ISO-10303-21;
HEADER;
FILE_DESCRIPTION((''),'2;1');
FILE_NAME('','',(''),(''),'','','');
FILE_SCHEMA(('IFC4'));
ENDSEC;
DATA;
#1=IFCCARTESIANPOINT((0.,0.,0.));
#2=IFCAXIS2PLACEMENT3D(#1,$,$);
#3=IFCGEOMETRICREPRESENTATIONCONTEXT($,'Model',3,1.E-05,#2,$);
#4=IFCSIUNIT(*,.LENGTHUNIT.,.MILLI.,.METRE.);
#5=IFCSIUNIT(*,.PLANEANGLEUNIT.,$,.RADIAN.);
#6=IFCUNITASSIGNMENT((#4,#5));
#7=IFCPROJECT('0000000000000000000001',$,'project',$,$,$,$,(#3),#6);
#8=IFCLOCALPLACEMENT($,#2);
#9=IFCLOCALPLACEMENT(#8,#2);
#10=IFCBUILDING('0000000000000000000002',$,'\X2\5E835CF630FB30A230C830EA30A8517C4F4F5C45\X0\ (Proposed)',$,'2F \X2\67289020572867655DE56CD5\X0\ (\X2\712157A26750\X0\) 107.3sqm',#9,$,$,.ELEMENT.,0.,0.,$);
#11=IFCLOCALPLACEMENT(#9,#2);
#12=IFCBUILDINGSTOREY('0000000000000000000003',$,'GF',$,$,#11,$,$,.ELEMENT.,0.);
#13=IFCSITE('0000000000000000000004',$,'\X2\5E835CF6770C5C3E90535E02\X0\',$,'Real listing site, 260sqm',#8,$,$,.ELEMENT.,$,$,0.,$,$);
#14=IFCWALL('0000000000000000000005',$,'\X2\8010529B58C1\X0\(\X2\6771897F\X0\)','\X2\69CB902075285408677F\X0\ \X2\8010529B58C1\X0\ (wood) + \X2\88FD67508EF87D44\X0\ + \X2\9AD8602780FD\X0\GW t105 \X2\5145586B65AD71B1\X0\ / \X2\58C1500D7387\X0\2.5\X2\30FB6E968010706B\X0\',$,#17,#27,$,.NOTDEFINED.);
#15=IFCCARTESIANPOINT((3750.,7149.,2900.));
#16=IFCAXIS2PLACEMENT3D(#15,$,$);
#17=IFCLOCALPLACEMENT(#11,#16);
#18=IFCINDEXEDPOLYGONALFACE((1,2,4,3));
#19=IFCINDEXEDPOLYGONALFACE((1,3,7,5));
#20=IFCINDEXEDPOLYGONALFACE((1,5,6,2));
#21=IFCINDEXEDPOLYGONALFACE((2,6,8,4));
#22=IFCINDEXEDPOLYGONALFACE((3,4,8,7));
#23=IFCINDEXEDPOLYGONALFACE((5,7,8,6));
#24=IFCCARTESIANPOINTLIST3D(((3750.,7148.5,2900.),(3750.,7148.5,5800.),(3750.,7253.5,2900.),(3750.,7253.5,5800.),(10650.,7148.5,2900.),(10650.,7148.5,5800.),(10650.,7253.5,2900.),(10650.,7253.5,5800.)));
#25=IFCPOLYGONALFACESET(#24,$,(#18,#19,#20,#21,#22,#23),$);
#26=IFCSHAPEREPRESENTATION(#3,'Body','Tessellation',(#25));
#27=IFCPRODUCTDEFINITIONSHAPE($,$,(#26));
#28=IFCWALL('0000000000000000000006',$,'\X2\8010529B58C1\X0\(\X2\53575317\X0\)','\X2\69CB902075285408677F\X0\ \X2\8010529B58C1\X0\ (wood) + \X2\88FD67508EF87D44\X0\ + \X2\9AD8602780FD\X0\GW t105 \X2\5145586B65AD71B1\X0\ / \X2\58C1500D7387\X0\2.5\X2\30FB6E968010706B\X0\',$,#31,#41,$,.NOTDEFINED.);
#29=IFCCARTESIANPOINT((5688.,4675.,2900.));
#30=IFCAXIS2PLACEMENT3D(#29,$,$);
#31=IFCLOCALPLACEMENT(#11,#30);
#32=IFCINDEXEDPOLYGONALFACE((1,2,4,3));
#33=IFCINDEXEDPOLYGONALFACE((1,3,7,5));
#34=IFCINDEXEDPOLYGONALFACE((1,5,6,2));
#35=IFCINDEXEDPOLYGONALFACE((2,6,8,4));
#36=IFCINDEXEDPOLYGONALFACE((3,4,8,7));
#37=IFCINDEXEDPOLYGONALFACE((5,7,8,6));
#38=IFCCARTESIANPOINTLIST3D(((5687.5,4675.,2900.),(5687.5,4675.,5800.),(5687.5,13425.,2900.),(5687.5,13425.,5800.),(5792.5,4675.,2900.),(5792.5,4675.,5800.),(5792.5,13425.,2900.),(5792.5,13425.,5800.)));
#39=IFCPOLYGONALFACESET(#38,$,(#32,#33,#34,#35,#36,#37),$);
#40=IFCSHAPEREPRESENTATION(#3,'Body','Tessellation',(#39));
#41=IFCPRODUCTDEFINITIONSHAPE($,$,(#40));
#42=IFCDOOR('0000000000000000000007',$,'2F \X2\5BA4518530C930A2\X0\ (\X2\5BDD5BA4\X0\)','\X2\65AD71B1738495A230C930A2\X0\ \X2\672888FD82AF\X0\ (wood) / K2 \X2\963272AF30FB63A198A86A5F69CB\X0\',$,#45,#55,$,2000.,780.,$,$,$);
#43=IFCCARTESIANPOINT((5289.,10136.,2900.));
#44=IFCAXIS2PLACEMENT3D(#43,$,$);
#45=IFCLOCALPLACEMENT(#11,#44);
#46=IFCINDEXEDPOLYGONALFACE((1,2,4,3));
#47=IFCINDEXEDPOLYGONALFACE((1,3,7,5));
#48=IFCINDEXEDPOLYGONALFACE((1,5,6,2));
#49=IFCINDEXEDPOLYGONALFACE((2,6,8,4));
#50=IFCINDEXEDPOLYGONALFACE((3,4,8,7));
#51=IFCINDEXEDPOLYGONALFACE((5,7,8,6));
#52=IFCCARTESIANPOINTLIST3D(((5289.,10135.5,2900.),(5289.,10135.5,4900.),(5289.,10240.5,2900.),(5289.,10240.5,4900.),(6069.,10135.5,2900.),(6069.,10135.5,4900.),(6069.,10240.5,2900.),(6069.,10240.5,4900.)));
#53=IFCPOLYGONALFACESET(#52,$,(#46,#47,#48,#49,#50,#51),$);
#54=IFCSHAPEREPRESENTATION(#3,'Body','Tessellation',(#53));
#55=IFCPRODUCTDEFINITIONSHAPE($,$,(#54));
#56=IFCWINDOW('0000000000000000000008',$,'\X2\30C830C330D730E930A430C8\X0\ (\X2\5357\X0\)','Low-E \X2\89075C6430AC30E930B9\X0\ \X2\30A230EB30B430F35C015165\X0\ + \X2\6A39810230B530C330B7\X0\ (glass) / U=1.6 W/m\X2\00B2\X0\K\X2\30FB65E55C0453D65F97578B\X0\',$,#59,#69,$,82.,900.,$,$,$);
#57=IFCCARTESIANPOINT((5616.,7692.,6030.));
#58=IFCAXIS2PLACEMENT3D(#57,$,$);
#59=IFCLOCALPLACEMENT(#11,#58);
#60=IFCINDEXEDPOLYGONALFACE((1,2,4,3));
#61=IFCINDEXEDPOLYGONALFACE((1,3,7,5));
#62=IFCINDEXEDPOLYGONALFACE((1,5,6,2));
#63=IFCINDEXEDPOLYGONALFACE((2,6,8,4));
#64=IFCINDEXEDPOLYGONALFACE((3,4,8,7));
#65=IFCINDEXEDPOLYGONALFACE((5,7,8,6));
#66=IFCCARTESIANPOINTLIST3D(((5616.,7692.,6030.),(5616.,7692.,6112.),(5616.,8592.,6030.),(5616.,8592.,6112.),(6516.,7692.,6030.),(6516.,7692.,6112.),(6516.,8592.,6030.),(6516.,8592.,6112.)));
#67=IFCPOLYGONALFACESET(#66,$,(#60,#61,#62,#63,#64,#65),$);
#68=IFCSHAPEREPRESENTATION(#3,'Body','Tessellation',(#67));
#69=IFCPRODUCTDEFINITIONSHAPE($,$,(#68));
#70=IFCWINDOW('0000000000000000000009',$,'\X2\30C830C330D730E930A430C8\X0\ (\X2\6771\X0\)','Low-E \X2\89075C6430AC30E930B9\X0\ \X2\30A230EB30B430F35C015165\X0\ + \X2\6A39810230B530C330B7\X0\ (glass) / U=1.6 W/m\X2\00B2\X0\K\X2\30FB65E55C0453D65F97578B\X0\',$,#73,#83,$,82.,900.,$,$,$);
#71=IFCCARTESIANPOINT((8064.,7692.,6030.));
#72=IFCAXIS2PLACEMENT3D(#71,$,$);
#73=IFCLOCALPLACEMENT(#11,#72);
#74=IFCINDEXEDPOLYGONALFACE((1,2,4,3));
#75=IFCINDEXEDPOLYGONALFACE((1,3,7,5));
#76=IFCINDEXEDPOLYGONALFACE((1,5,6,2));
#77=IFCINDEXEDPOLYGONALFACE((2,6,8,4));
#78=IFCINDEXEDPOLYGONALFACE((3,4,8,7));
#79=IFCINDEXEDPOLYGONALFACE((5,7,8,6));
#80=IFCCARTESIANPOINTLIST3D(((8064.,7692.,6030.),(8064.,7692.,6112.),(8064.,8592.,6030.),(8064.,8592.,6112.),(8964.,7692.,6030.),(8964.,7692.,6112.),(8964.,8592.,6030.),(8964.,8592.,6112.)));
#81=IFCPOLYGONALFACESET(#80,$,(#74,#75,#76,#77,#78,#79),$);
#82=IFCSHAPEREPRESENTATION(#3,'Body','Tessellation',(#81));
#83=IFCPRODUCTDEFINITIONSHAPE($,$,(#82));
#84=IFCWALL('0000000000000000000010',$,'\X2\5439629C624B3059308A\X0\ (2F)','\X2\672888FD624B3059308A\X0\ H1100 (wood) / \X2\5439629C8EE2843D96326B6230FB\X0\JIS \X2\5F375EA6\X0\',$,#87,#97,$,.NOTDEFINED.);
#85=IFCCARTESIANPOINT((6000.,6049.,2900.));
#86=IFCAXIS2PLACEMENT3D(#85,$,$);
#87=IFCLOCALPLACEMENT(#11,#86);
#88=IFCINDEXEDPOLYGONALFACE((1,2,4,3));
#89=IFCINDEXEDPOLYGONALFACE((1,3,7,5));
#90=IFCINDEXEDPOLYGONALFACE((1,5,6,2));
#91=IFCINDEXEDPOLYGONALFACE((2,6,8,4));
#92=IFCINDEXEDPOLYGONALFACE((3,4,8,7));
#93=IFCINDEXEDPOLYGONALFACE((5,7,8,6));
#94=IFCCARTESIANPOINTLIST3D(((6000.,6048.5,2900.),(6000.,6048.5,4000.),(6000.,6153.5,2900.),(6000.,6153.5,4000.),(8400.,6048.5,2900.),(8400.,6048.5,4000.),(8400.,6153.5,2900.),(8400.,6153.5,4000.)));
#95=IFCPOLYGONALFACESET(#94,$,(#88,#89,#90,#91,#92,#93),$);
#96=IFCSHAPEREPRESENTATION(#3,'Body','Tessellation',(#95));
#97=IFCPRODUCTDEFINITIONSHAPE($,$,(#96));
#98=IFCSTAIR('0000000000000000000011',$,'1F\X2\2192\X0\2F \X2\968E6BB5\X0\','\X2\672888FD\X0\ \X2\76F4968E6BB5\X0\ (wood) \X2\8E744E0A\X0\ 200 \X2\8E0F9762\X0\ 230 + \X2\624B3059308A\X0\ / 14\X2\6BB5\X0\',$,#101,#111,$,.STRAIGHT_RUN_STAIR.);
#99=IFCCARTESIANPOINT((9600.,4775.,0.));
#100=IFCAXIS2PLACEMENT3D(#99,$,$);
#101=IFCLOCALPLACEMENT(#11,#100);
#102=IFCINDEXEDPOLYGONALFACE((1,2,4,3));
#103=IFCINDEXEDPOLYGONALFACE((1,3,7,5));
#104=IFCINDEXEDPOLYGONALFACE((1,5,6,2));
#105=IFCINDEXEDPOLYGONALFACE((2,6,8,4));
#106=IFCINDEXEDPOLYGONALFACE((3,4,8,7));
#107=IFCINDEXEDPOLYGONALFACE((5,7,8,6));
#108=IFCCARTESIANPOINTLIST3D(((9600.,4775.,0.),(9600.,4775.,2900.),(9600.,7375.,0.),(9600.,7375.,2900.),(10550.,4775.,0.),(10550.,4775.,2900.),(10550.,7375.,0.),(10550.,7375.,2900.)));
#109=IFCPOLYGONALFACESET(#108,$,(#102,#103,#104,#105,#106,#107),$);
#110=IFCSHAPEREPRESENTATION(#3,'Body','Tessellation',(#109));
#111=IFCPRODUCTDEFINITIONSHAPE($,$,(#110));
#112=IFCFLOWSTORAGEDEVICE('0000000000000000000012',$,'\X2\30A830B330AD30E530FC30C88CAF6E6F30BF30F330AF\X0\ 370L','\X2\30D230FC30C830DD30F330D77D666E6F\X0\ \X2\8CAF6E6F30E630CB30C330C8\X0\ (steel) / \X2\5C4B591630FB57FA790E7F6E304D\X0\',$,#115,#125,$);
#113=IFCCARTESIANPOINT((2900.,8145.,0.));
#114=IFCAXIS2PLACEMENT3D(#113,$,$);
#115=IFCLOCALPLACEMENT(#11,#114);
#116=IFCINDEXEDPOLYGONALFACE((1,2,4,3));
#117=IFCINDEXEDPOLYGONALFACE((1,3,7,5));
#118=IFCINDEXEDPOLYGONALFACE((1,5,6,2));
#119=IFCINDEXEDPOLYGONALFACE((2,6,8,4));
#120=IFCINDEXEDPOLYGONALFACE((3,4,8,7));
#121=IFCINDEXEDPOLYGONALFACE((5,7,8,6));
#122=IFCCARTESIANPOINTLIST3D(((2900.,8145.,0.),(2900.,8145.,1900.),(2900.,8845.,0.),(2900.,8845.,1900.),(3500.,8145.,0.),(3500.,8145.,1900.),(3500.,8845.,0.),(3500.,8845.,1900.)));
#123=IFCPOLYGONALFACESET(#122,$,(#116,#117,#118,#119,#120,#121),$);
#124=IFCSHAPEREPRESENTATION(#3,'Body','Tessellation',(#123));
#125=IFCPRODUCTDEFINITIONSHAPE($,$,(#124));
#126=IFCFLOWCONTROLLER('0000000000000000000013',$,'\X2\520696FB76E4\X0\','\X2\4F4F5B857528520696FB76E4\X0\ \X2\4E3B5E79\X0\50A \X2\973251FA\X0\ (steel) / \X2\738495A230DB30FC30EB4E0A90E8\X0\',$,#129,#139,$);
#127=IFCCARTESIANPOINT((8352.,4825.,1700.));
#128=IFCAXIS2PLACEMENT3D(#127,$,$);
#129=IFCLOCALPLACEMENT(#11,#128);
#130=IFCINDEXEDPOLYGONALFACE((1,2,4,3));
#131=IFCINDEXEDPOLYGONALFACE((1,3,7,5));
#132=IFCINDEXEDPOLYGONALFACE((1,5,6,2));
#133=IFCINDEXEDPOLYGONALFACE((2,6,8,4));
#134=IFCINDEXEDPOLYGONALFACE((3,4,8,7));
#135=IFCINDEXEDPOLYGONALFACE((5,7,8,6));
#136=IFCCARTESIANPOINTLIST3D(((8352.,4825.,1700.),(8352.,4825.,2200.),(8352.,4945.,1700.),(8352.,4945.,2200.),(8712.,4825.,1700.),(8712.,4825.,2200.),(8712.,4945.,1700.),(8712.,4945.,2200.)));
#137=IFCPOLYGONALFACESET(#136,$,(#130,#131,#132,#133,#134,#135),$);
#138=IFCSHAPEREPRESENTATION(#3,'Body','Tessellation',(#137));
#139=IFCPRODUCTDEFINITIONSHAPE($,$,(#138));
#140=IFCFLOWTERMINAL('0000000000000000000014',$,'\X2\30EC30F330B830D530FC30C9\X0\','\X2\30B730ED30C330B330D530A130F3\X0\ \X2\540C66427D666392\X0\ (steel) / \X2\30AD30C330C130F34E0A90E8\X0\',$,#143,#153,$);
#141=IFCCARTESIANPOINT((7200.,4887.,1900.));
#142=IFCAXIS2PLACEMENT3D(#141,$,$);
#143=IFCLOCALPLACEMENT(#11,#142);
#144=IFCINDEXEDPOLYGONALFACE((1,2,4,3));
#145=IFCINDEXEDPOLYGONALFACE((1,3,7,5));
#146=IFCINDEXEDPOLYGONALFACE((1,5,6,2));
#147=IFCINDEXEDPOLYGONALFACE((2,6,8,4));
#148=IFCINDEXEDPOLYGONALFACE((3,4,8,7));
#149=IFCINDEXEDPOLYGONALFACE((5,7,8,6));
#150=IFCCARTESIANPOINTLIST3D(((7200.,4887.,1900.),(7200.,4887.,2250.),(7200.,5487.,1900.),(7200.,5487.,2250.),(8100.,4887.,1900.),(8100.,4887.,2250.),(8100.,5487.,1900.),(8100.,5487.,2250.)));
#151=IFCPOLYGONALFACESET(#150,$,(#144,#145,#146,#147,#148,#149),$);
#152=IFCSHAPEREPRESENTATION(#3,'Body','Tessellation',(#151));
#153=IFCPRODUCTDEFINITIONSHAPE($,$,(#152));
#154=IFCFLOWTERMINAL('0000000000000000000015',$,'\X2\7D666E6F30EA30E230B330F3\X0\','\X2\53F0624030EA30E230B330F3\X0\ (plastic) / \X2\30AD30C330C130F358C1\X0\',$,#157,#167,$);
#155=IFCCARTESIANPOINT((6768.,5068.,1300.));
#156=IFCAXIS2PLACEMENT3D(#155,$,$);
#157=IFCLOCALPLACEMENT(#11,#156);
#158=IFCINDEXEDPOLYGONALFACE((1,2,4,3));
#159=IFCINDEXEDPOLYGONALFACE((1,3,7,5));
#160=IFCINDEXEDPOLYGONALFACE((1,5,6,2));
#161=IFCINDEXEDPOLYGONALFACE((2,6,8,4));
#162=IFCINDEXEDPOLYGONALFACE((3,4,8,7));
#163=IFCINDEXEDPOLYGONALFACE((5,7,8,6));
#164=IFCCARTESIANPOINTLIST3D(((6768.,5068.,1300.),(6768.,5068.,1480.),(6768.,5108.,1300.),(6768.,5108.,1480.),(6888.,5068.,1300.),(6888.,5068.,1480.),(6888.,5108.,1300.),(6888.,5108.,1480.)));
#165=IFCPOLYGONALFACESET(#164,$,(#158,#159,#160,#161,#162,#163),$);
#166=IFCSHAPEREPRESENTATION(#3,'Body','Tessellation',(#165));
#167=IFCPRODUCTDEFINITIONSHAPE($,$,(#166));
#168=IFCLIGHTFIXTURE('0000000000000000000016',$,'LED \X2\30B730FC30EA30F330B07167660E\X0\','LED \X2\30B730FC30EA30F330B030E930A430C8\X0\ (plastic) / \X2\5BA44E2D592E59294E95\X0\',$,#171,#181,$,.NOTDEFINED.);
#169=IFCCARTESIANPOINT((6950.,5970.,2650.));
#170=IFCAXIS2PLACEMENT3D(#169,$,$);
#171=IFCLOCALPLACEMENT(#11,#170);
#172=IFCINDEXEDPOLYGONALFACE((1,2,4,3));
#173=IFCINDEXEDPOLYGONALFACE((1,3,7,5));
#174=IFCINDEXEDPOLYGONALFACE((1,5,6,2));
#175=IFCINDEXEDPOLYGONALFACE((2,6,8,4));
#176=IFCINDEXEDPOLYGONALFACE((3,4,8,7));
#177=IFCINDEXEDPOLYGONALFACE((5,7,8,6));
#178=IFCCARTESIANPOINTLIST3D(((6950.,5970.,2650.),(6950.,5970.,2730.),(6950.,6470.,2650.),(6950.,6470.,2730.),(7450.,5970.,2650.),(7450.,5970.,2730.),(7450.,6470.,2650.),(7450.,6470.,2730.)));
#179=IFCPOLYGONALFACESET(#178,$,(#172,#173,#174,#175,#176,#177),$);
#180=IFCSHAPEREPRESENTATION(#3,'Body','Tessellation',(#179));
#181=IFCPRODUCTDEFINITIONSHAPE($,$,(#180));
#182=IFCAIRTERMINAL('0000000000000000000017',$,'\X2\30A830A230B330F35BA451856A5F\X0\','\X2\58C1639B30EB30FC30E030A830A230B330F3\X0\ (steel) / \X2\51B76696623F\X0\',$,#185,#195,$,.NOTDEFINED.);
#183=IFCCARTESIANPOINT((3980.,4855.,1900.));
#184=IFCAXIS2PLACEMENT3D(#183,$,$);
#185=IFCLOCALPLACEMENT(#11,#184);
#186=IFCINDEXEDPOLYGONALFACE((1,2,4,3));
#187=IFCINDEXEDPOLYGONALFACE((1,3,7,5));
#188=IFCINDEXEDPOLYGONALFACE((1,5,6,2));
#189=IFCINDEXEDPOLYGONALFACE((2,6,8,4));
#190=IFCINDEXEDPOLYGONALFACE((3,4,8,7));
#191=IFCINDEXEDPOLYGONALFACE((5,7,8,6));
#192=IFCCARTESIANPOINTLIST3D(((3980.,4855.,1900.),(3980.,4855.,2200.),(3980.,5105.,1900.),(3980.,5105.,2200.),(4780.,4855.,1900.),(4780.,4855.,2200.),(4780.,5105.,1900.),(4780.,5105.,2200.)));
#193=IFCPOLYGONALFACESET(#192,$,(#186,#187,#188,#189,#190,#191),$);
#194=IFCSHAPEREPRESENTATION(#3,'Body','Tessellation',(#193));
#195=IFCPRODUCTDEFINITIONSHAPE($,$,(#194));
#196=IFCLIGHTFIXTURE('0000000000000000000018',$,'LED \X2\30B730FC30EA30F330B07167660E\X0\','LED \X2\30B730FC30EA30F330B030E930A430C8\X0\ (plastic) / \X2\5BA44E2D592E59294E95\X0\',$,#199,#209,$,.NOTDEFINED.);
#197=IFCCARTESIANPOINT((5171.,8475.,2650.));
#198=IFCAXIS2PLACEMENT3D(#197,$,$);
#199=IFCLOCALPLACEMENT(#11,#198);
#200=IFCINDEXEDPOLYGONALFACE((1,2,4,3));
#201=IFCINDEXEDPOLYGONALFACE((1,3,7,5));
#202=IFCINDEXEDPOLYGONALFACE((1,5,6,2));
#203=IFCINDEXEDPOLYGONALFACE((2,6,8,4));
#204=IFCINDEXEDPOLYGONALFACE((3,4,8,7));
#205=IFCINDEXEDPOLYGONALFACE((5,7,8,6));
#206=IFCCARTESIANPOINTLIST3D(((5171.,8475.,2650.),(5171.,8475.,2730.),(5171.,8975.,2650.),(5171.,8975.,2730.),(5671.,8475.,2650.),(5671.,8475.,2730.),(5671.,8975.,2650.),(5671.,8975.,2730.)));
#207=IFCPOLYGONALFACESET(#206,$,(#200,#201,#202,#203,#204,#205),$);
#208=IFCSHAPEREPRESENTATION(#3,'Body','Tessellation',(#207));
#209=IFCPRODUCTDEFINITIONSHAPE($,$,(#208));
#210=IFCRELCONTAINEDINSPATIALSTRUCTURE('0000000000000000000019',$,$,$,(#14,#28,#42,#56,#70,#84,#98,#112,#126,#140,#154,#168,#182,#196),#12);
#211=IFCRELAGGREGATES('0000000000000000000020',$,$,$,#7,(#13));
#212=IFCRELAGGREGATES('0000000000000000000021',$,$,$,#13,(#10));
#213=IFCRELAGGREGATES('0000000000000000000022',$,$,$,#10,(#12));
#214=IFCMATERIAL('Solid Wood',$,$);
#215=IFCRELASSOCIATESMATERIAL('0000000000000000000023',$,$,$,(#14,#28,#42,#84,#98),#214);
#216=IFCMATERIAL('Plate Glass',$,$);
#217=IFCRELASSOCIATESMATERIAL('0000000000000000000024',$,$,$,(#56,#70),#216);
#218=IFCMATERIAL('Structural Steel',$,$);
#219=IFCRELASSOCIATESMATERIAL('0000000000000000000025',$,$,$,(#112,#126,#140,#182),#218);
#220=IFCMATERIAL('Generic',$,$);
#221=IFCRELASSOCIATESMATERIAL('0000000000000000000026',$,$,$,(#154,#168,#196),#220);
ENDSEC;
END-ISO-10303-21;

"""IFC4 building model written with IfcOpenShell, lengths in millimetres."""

from ifc_helpers import new_model, si_unit, frame, frame_2d, origin, place, context, project, spatial, rectangle, extrude, material, element, fill, save


model = new_model("IFC4")

# Units and contexts
model_context = context("Model", 3, precision=1e-05, world=origin())
ifc_project = project(units=[si_unit("LENGTHUNIT", "METRE", prefix="MILLI"), si_unit("PLANEANGLEUNIT", "RADIAN")], contexts=[model_context])

# Site, building, storey
site_placement = place(None, origin())
site = spatial("IfcSite", under=ifc_project, at=site_placement, Name="広島県尾道市", ObjectType="Real listing site, 260sqm", CompositionType="ELEMENT", RefElevation=0.0)
building_placement = place(site_placement, origin())
building = spatial("IfcBuilding", under=site, at=building_placement, Name="広島・アトリエ兼住居 (Proposed)", ObjectType="2F 木造在来工法 (無垢材) 107.3sqm", CompositionType="ELEMENT", ElevationOfRefHeight=0.0, ElevationOfTerrain=0.0)
storey_placement = place(building_placement, origin())
storey = spatial("IfcBuildingStorey", under=building, at=storey_placement, Name="GF", CompositionType="ELEMENT", Elevation=0.0)

# Shared definitions
ifc_material_1 = material(Name="Solid Wood")

# Wall
wall_1_placement = place(storey_placement, frame((3750.0, 7149.0, 2900.0)))
element("IfcWall", 1, at=wall_1_placement, inside=storey, material=ifc_material_1, Name="耐力壁(東西)", Description="構造用合板 耐力壁 (wood) + 製材軸組 + 高性能GW t105 充填断熱 / 壁倍率2.5・準耐火", PredefinedType="NOTDEFINED", context=model_context, shape_type="SweptSolid", body=[
    extrude(rectangle(XDim=6900.0, YDim=105.0, at=frame_2d((3450.0, 52.0))), frame((3750.0, 7149.0, 2900.0)), (0.0, 0.0, 1.0), 2900.0),
])

# Wall, opening, door
wall_2_placement = place(storey_placement, frame((5688.0, 4675.0, 2900.0)))
wall_2 = element("IfcWall", 2, at=wall_2_placement, inside=storey, material=ifc_material_1, Name="耐力壁(南北)", Description="構造用合板 耐力壁 (wood) + 製材軸組 + 高性能GW t105 充填断熱 / 壁倍率2.5・準耐火", PredefinedType="NOTDEFINED", context=model_context, shape_type="SweptSolid", body=[
    extrude(rectangle(XDim=105.0, YDim=8750.0, at=frame_2d((52.0, 4375.0))), frame((5688.0, 4675.0, 2900.0)), (0.0, 0.0, 1.0), 2900.0),
])
opening_placement = place(storey_placement, frame((5289.0, 10136.0, 2900.0)))
opening = element("IfcOpeningElement", 3, at=opening_placement, cuts=wall_2, PredefinedType="NOTDEFINED", context=model_context, shape_type="SweptSolid", body=[
    extrude(rectangle(XDim=780.0, YDim=105.0, at=frame_2d((390.0, 52.0))), frame((5289.0, 10136.0, 2900.0)), (0.0, 0.0, 1.0), 2000.0),
])
door_placement = place(storey_placement, frame((5289.0, 10136.0, 2900.0)))
door = element("IfcDoor", 4, at=door_placement, inside=storey, material=ifc_material_1, Name="2F 室内ドア (寝室)", Description="断熱玄関ドア 木製芯 (wood) / K2 防犯・採風機構", OverallHeight=2000.0, OverallWidth=780.0, context=model_context, shape_type="SweptSolid", body=[
    extrude(rectangle(XDim=780.0, YDim=105.0, at=frame_2d((390.0, 52.0))), frame((5289.0, 10136.0, 2900.0)), (0.0, 0.0, 1.0), 2000.0),
])
fill(opening, door)

# Windows
ifc_material_2 = material(Name="Plate Glass")
window_1_placement = place(storey_placement, frame((5616.0, 7692.0, 6030.0)))
element("IfcWindow", 5, at=window_1_placement, inside=storey, material=ifc_material_2, Name="トップライト (南)", Description="Low-E 複層ガラス アルゴン封入 + 樹脂サッシ (glass) / U=1.6 W/m²K・日射取得型", OverallHeight=82.0, OverallWidth=900.0, context=model_context, shape_type="SweptSolid", body=[
    extrude(rectangle(XDim=900.0, YDim=900.0, at=frame_2d((450.0, 450.0))), frame((5616.0, 7692.0, 6030.0)), (0.0, 0.0, 1.0), 82.0),
])
window_2_placement = place(storey_placement, frame((8064.0, 7692.0, 6030.0)))
element("IfcWindow", 6, at=window_2_placement, inside=storey, material=ifc_material_2, Name="トップライト (東)", Description="Low-E 複層ガラス アルゴン封入 + 樹脂サッシ (glass) / U=1.6 W/m²K・日射取得型", OverallHeight=82.0, OverallWidth=900.0, context=model_context, shape_type="SweptSolid", body=[
    extrude(rectangle(XDim=900.0, YDim=900.0, at=frame_2d((450.0, 450.0))), frame((8064.0, 7692.0, 6030.0)), (0.0, 0.0, 1.0), 82.0),
])

# Wall
wall_3_placement = place(storey_placement, frame((6000.0, 6049.0, 2900.0)))
element("IfcWall", 7, at=wall_3_placement, inside=storey, material=ifc_material_1, Name="吹抜手すり (2F)", Description="木製手すり H1100 (wood) / 吹抜転落防止・JIS 強度", PredefinedType="NOTDEFINED", context=model_context, shape_type="SweptSolid", body=[
    extrude(rectangle(XDim=2400.0, YDim=105.0, at=frame_2d((1200.0, 52.0))), frame((6000.0, 6049.0, 2900.0)), (0.0, 0.0, 1.0), 1100.0),
])

# Stair
stair_placement = place(storey_placement, frame((9600.0, 4775.0, 0.0)))
element("IfcStair", 8, at=stair_placement, inside=storey, material=ifc_material_1, Name="1F→2F 階段", Description="木製 直階段 (wood) 蹴上 200 踏面 230 + 手すり / 14段", PredefinedType="STRAIGHT_RUN_STAIR", context=model_context, shape_type="SweptSolid", body=[
    extrude(rectangle(XDim=950.0, YDim=2600.0, at=frame_2d((475.0, 1300.0))), frame((9600.0, 4775.0, 0.0)), (0.0, 0.0, 1.0), 2900.0),
])

# Flow storage device
ifc_material_3 = material(Name="Structural Steel")
flow_storage_device_placement = place(storey_placement, frame((2900.0, 8145.0, 0.0)))
element("IfcFlowStorageDevice", 9, at=flow_storage_device_placement, inside=storey, material=ifc_material_3, Name="エコキュート貯湯タンク 370L", Description="ヒートポンプ給湯 貯湯ユニット (steel) / 屋外・基礎置き", context=model_context, shape_type="SweptSolid", body=[
    extrude(rectangle(XDim=600.0, YDim=700.0, at=frame_2d((300.0, 350.0))), frame((2900.0, 8145.0, 0.0)), (0.0, 0.0, 1.0), 1900.0),
])

# Flow controller
flow_controller_placement = place(storey_placement, frame((8352.0, 4825.0, 1700.0)))
element("IfcFlowController", 10, at=flow_controller_placement, inside=storey, material=ifc_material_3, Name="分電盤", Description="住宅用分電盤 主幹50A 露出 (steel) / 玄関ホール上部", context=model_context, shape_type="SweptSolid", body=[
    extrude(rectangle(XDim=360.0, YDim=120.0, at=frame_2d((180.0, 60.0))), frame((8352.0, 4825.0, 1700.0)), (0.0, 0.0, 1.0), 500.0),
])

# Flow terminals
flow_terminal_1_placement = place(storey_placement, frame((7200.0, 4887.0, 1900.0)))
element("IfcFlowTerminal", 11, at=flow_terminal_1_placement, inside=storey, material=ifc_material_3, Name="レンジフード", Description="シロッコファン 同時給排 (steel) / キッチン上部", context=model_context, shape_type="SweptSolid", body=[
    extrude(rectangle(XDim=900.0, YDim=600.0, at=frame_2d((450.0, 300.0))), frame((7200.0, 4887.0, 1900.0)), (0.0, 0.0, 1.0), 350.0),
])
ifc_material_4 = material(Name="Generic")
flow_terminal_2_placement = place(storey_placement, frame((6768.0, 5068.0, 1300.0)))
element("IfcFlowTerminal", 12, at=flow_terminal_2_placement, inside=storey, material=ifc_material_4, Name="給湯リモコン", Description="台所リモコン (plastic) / キッチン壁", context=model_context, shape_type="SweptSolid", body=[
    extrude(rectangle(XDim=120.0, YDim=40.0, at=frame_2d((60.0, 20.0))), frame((6768.0, 5068.0, 1300.0)), (0.0, 0.0, 1.0), 180.0),
])

# Light fixture
light_fixture_1_placement = place(storey_placement, frame((6950.0, 5970.0, 2650.0)))
element("IfcLightFixture", 13, at=light_fixture_1_placement, inside=storey, material=ifc_material_4, Name="LED シーリング照明", Description="LED シーリングライト (plastic) / 室中央天井", PredefinedType="NOTDEFINED", context=model_context, shape_type="SweptSolid", body=[
    extrude(rectangle(XDim=500.0, YDim=500.0, at=frame_2d((250.0, 250.0))), frame((6950.0, 5970.0, 2650.0)), (0.0, 0.0, 1.0), 80.0),
])

# Air terminal
air_terminal_1_placement = place(storey_placement, frame((3980.0, 4855.0, 1900.0)))
element("IfcAirTerminal", 14, at=air_terminal_1_placement, inside=storey, material=ifc_material_3, Name="エアコン室内機", Description="壁掛ルームエアコン (steel) / 冷暖房", PredefinedType="NOTDEFINED", context=model_context, shape_type="SweptSolid", body=[
    extrude(rectangle(XDim=800.0, YDim=250.0, at=frame_2d((400.0, 125.0))), frame((3980.0, 4855.0, 1900.0)), (0.0, 0.0, 1.0), 300.0),
])

# Light fixture
light_fixture_2_placement = place(storey_placement, frame((5171.0, 8475.0, 2650.0)))
element("IfcLightFixture", 15, at=light_fixture_2_placement, inside=storey, material=ifc_material_4, Name="LED シーリング照明", Description="LED シーリングライト (plastic) / 室中央天井", PredefinedType="NOTDEFINED", context=model_context, shape_type="SweptSolid", body=[
    extrude(rectangle(XDim=500.0, YDim=500.0, at=frame_2d((250.0, 250.0))), frame((5171.0, 8475.0, 2650.0)), (0.0, 0.0, 1.0), 80.0),
])

save(model, "model.ifc")
